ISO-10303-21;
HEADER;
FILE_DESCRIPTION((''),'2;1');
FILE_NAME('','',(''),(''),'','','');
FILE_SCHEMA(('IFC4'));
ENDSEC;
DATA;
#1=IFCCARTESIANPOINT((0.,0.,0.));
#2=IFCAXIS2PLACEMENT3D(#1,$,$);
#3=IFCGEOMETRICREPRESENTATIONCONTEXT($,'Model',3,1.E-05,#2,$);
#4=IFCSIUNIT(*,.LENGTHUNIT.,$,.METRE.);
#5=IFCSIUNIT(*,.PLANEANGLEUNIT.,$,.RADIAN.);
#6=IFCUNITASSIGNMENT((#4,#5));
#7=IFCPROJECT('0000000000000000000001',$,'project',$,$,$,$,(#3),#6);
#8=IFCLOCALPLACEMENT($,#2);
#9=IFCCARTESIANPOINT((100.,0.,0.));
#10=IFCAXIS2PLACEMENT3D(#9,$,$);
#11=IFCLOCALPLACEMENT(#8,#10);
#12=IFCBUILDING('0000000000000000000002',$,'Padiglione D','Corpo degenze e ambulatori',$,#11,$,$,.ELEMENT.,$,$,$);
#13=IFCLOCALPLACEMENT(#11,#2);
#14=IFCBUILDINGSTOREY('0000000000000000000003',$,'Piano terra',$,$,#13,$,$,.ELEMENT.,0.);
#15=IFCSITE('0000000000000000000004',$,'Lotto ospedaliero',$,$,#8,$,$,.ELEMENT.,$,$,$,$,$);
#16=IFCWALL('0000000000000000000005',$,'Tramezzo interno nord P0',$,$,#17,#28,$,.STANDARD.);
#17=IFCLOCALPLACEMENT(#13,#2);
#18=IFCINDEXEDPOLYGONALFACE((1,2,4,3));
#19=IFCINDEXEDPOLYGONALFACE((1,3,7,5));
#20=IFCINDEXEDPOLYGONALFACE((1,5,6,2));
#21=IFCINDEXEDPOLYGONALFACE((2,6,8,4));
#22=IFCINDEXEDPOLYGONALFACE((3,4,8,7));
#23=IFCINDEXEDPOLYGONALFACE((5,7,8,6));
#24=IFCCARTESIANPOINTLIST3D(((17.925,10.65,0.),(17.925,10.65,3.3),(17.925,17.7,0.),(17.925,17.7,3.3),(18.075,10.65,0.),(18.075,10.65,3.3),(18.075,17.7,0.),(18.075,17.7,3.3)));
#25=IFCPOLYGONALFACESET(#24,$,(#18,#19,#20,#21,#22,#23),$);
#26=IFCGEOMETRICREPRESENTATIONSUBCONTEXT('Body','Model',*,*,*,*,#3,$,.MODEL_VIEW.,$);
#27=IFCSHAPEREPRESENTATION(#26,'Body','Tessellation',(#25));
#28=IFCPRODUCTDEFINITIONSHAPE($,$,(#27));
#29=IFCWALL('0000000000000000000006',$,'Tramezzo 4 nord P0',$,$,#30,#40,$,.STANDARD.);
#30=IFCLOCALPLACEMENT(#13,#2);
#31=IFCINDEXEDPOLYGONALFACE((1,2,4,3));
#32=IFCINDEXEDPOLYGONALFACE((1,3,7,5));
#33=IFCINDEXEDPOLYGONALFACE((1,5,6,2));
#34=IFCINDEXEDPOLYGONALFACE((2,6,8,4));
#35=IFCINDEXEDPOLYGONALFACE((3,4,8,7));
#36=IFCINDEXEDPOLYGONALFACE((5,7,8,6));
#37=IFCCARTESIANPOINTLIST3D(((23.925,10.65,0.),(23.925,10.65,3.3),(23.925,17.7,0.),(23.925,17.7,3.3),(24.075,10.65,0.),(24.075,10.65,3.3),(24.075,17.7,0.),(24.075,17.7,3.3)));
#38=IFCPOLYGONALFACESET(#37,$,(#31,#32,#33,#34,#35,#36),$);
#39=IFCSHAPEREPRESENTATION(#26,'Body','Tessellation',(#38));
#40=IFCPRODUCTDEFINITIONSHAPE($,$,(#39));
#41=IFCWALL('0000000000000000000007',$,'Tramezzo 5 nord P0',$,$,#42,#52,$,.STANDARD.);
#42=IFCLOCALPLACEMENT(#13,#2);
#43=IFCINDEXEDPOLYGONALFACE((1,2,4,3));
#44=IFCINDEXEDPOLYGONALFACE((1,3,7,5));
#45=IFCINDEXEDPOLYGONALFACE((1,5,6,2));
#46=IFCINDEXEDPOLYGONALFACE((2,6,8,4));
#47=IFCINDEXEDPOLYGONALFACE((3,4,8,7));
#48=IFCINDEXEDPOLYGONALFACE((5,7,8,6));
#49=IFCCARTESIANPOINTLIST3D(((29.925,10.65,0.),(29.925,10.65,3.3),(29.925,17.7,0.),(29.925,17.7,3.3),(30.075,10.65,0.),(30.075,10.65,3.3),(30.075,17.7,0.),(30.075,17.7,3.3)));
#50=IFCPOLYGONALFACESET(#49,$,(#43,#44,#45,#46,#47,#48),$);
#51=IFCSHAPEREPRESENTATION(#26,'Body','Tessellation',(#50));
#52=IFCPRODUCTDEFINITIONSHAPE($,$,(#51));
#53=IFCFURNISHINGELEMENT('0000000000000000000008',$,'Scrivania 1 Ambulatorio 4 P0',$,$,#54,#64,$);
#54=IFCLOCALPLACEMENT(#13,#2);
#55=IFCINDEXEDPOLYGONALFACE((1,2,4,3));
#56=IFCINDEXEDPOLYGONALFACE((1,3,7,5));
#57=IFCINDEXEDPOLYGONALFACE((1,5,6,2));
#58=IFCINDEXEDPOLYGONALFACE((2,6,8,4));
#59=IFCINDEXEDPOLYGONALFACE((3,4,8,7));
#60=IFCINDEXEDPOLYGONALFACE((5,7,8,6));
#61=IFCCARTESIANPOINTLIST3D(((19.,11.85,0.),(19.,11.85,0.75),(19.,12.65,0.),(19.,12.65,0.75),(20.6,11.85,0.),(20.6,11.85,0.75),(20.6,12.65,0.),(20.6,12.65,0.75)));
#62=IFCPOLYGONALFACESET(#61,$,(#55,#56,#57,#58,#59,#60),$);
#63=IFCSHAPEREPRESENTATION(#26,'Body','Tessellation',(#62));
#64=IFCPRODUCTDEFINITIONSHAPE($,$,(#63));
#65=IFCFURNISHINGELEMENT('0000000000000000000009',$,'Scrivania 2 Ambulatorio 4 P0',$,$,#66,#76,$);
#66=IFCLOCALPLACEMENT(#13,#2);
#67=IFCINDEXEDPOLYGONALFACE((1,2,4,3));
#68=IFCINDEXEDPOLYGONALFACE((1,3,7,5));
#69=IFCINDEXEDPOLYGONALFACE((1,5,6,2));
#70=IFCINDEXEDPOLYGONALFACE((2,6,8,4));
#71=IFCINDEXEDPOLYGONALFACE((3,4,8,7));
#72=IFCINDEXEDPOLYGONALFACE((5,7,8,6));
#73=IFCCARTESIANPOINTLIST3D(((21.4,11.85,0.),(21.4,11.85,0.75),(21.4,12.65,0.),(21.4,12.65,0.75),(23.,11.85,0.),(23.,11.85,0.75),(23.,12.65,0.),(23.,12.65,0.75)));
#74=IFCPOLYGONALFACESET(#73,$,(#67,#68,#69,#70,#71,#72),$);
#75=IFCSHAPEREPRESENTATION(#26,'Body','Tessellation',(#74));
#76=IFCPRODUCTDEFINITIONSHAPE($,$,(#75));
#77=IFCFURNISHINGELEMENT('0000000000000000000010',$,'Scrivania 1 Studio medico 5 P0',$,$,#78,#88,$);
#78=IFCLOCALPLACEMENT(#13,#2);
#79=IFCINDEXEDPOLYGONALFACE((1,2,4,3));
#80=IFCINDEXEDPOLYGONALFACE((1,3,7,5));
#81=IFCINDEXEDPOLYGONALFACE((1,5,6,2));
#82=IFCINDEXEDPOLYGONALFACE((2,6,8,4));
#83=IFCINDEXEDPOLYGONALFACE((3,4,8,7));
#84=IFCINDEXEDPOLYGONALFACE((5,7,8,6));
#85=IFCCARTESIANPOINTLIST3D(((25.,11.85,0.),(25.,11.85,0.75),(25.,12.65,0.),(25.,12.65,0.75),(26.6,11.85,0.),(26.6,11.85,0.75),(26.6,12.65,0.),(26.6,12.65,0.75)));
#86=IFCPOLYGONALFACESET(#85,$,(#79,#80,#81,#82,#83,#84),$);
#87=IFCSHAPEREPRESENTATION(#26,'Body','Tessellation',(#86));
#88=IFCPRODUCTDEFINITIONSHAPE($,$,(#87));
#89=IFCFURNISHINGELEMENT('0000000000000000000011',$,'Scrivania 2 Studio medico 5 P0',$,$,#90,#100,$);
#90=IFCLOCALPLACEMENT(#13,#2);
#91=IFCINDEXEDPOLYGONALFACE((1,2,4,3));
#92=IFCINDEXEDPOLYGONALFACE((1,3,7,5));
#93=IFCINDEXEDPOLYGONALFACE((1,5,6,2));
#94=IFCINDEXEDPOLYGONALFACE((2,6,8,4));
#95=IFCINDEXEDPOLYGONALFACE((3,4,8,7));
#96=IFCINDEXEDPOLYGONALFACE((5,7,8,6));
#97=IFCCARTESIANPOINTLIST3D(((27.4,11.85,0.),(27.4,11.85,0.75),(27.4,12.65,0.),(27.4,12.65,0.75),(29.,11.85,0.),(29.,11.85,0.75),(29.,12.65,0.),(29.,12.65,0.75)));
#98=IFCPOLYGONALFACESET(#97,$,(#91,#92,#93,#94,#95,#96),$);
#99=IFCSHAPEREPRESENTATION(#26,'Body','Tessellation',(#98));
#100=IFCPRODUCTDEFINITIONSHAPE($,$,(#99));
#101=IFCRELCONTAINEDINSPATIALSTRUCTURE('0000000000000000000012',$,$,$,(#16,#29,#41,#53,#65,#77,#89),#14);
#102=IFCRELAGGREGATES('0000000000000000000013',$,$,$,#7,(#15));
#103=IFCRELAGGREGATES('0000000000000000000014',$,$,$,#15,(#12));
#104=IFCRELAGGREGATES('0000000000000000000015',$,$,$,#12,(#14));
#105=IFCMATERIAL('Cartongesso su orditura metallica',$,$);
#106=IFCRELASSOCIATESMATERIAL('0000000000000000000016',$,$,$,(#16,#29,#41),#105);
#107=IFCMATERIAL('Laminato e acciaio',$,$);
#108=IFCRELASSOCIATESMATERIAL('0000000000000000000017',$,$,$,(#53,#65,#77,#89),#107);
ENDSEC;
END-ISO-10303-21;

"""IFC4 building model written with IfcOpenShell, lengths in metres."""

from ifc_helpers import new_model, si_unit, frame, frame_2d, origin, place, context, subcontext, project, spatial, rectangle, extrude, material, element, save


model = new_model("IFC4")

# Units and contexts
model_context = context("Model", 3, precision=1e-05, world=origin())
body_context = subcontext(model_context, "Body", "Model", "MODEL_VIEW")
ifc_project = project(units=[si_unit("LENGTHUNIT", "METRE"), si_unit("PLANEANGLEUNIT", "RADIAN")], contexts=[model_context])

# Site, building, storey
site_placement = place(None, origin())
site = spatial("IfcSite", under=ifc_project, at=site_placement, Name="Lotto ospedaliero", CompositionType="ELEMENT")
building_placement = place(site_placement, frame((100.0, 0.0, 0.0)))
building = spatial("IfcBuilding", under=site, at=building_placement, Name="Padiglione D", Description="Corpo degenze e ambulatori", CompositionType="ELEMENT")
storey_placement = place(building_placement, origin())
storey = spatial("IfcBuildingStorey", under=building, at=storey_placement, Name="Piano terra", CompositionType="ELEMENT", Elevation=0.0)

# Walls
ifc_material_1 = material(Name="Cartongesso su orditura metallica")
for number, where, name in (
    (1, (17.925, 10.65, 0.0), "Tramezzo interno nord P0"),
    (2, (23.925, 10.65, 0.0), "Tramezzo 4 nord P0"),
    (3, (29.925, 10.65, 0.0), "Tramezzo 5 nord P0"),
):
    element("IfcWall", number, at=place(storey_placement, frame(where)), inside=storey, material=ifc_material_1, Name=name, PredefinedType="STANDARD", context=body_context, shape_type="SweptSolid", body=[
        extrude(rectangle(XDim=0.15, YDim=7.05, at=frame_2d((0.075, 3.525))), origin(), (0.0, 0.0, 1.0), 3.3),
    ])

# Furnishing elements
ifc_material_2 = material(Name="Laminato e acciaio")
for number, where, name in (
    (4, (19.0, 11.85, 0.0), "Scrivania 1 Ambulatorio 4 P0"),
    (5, (21.4, 11.85, 0.0), "Scrivania 2 Ambulatorio 4 P0"),
    (6, (25.0, 11.85, 0.0), "Scrivania 1 Studio medico 5 P0"),
    (7, (27.4, 11.85, 0.0), "Scrivania 2 Studio medico 5 P0"),
):
    element("IfcFurnishingElement", number, at=place(storey_placement, frame(where)), inside=storey, material=ifc_material_2, Name=name, context=body_context, shape_type="SweptSolid", body=[
        extrude(rectangle(XDim=1.6, YDim=0.8, at=frame_2d((0.8, 0.4))), origin(), (0.0, 0.0, 1.0), 0.75),
    ])

save(model, "model.ifc")
